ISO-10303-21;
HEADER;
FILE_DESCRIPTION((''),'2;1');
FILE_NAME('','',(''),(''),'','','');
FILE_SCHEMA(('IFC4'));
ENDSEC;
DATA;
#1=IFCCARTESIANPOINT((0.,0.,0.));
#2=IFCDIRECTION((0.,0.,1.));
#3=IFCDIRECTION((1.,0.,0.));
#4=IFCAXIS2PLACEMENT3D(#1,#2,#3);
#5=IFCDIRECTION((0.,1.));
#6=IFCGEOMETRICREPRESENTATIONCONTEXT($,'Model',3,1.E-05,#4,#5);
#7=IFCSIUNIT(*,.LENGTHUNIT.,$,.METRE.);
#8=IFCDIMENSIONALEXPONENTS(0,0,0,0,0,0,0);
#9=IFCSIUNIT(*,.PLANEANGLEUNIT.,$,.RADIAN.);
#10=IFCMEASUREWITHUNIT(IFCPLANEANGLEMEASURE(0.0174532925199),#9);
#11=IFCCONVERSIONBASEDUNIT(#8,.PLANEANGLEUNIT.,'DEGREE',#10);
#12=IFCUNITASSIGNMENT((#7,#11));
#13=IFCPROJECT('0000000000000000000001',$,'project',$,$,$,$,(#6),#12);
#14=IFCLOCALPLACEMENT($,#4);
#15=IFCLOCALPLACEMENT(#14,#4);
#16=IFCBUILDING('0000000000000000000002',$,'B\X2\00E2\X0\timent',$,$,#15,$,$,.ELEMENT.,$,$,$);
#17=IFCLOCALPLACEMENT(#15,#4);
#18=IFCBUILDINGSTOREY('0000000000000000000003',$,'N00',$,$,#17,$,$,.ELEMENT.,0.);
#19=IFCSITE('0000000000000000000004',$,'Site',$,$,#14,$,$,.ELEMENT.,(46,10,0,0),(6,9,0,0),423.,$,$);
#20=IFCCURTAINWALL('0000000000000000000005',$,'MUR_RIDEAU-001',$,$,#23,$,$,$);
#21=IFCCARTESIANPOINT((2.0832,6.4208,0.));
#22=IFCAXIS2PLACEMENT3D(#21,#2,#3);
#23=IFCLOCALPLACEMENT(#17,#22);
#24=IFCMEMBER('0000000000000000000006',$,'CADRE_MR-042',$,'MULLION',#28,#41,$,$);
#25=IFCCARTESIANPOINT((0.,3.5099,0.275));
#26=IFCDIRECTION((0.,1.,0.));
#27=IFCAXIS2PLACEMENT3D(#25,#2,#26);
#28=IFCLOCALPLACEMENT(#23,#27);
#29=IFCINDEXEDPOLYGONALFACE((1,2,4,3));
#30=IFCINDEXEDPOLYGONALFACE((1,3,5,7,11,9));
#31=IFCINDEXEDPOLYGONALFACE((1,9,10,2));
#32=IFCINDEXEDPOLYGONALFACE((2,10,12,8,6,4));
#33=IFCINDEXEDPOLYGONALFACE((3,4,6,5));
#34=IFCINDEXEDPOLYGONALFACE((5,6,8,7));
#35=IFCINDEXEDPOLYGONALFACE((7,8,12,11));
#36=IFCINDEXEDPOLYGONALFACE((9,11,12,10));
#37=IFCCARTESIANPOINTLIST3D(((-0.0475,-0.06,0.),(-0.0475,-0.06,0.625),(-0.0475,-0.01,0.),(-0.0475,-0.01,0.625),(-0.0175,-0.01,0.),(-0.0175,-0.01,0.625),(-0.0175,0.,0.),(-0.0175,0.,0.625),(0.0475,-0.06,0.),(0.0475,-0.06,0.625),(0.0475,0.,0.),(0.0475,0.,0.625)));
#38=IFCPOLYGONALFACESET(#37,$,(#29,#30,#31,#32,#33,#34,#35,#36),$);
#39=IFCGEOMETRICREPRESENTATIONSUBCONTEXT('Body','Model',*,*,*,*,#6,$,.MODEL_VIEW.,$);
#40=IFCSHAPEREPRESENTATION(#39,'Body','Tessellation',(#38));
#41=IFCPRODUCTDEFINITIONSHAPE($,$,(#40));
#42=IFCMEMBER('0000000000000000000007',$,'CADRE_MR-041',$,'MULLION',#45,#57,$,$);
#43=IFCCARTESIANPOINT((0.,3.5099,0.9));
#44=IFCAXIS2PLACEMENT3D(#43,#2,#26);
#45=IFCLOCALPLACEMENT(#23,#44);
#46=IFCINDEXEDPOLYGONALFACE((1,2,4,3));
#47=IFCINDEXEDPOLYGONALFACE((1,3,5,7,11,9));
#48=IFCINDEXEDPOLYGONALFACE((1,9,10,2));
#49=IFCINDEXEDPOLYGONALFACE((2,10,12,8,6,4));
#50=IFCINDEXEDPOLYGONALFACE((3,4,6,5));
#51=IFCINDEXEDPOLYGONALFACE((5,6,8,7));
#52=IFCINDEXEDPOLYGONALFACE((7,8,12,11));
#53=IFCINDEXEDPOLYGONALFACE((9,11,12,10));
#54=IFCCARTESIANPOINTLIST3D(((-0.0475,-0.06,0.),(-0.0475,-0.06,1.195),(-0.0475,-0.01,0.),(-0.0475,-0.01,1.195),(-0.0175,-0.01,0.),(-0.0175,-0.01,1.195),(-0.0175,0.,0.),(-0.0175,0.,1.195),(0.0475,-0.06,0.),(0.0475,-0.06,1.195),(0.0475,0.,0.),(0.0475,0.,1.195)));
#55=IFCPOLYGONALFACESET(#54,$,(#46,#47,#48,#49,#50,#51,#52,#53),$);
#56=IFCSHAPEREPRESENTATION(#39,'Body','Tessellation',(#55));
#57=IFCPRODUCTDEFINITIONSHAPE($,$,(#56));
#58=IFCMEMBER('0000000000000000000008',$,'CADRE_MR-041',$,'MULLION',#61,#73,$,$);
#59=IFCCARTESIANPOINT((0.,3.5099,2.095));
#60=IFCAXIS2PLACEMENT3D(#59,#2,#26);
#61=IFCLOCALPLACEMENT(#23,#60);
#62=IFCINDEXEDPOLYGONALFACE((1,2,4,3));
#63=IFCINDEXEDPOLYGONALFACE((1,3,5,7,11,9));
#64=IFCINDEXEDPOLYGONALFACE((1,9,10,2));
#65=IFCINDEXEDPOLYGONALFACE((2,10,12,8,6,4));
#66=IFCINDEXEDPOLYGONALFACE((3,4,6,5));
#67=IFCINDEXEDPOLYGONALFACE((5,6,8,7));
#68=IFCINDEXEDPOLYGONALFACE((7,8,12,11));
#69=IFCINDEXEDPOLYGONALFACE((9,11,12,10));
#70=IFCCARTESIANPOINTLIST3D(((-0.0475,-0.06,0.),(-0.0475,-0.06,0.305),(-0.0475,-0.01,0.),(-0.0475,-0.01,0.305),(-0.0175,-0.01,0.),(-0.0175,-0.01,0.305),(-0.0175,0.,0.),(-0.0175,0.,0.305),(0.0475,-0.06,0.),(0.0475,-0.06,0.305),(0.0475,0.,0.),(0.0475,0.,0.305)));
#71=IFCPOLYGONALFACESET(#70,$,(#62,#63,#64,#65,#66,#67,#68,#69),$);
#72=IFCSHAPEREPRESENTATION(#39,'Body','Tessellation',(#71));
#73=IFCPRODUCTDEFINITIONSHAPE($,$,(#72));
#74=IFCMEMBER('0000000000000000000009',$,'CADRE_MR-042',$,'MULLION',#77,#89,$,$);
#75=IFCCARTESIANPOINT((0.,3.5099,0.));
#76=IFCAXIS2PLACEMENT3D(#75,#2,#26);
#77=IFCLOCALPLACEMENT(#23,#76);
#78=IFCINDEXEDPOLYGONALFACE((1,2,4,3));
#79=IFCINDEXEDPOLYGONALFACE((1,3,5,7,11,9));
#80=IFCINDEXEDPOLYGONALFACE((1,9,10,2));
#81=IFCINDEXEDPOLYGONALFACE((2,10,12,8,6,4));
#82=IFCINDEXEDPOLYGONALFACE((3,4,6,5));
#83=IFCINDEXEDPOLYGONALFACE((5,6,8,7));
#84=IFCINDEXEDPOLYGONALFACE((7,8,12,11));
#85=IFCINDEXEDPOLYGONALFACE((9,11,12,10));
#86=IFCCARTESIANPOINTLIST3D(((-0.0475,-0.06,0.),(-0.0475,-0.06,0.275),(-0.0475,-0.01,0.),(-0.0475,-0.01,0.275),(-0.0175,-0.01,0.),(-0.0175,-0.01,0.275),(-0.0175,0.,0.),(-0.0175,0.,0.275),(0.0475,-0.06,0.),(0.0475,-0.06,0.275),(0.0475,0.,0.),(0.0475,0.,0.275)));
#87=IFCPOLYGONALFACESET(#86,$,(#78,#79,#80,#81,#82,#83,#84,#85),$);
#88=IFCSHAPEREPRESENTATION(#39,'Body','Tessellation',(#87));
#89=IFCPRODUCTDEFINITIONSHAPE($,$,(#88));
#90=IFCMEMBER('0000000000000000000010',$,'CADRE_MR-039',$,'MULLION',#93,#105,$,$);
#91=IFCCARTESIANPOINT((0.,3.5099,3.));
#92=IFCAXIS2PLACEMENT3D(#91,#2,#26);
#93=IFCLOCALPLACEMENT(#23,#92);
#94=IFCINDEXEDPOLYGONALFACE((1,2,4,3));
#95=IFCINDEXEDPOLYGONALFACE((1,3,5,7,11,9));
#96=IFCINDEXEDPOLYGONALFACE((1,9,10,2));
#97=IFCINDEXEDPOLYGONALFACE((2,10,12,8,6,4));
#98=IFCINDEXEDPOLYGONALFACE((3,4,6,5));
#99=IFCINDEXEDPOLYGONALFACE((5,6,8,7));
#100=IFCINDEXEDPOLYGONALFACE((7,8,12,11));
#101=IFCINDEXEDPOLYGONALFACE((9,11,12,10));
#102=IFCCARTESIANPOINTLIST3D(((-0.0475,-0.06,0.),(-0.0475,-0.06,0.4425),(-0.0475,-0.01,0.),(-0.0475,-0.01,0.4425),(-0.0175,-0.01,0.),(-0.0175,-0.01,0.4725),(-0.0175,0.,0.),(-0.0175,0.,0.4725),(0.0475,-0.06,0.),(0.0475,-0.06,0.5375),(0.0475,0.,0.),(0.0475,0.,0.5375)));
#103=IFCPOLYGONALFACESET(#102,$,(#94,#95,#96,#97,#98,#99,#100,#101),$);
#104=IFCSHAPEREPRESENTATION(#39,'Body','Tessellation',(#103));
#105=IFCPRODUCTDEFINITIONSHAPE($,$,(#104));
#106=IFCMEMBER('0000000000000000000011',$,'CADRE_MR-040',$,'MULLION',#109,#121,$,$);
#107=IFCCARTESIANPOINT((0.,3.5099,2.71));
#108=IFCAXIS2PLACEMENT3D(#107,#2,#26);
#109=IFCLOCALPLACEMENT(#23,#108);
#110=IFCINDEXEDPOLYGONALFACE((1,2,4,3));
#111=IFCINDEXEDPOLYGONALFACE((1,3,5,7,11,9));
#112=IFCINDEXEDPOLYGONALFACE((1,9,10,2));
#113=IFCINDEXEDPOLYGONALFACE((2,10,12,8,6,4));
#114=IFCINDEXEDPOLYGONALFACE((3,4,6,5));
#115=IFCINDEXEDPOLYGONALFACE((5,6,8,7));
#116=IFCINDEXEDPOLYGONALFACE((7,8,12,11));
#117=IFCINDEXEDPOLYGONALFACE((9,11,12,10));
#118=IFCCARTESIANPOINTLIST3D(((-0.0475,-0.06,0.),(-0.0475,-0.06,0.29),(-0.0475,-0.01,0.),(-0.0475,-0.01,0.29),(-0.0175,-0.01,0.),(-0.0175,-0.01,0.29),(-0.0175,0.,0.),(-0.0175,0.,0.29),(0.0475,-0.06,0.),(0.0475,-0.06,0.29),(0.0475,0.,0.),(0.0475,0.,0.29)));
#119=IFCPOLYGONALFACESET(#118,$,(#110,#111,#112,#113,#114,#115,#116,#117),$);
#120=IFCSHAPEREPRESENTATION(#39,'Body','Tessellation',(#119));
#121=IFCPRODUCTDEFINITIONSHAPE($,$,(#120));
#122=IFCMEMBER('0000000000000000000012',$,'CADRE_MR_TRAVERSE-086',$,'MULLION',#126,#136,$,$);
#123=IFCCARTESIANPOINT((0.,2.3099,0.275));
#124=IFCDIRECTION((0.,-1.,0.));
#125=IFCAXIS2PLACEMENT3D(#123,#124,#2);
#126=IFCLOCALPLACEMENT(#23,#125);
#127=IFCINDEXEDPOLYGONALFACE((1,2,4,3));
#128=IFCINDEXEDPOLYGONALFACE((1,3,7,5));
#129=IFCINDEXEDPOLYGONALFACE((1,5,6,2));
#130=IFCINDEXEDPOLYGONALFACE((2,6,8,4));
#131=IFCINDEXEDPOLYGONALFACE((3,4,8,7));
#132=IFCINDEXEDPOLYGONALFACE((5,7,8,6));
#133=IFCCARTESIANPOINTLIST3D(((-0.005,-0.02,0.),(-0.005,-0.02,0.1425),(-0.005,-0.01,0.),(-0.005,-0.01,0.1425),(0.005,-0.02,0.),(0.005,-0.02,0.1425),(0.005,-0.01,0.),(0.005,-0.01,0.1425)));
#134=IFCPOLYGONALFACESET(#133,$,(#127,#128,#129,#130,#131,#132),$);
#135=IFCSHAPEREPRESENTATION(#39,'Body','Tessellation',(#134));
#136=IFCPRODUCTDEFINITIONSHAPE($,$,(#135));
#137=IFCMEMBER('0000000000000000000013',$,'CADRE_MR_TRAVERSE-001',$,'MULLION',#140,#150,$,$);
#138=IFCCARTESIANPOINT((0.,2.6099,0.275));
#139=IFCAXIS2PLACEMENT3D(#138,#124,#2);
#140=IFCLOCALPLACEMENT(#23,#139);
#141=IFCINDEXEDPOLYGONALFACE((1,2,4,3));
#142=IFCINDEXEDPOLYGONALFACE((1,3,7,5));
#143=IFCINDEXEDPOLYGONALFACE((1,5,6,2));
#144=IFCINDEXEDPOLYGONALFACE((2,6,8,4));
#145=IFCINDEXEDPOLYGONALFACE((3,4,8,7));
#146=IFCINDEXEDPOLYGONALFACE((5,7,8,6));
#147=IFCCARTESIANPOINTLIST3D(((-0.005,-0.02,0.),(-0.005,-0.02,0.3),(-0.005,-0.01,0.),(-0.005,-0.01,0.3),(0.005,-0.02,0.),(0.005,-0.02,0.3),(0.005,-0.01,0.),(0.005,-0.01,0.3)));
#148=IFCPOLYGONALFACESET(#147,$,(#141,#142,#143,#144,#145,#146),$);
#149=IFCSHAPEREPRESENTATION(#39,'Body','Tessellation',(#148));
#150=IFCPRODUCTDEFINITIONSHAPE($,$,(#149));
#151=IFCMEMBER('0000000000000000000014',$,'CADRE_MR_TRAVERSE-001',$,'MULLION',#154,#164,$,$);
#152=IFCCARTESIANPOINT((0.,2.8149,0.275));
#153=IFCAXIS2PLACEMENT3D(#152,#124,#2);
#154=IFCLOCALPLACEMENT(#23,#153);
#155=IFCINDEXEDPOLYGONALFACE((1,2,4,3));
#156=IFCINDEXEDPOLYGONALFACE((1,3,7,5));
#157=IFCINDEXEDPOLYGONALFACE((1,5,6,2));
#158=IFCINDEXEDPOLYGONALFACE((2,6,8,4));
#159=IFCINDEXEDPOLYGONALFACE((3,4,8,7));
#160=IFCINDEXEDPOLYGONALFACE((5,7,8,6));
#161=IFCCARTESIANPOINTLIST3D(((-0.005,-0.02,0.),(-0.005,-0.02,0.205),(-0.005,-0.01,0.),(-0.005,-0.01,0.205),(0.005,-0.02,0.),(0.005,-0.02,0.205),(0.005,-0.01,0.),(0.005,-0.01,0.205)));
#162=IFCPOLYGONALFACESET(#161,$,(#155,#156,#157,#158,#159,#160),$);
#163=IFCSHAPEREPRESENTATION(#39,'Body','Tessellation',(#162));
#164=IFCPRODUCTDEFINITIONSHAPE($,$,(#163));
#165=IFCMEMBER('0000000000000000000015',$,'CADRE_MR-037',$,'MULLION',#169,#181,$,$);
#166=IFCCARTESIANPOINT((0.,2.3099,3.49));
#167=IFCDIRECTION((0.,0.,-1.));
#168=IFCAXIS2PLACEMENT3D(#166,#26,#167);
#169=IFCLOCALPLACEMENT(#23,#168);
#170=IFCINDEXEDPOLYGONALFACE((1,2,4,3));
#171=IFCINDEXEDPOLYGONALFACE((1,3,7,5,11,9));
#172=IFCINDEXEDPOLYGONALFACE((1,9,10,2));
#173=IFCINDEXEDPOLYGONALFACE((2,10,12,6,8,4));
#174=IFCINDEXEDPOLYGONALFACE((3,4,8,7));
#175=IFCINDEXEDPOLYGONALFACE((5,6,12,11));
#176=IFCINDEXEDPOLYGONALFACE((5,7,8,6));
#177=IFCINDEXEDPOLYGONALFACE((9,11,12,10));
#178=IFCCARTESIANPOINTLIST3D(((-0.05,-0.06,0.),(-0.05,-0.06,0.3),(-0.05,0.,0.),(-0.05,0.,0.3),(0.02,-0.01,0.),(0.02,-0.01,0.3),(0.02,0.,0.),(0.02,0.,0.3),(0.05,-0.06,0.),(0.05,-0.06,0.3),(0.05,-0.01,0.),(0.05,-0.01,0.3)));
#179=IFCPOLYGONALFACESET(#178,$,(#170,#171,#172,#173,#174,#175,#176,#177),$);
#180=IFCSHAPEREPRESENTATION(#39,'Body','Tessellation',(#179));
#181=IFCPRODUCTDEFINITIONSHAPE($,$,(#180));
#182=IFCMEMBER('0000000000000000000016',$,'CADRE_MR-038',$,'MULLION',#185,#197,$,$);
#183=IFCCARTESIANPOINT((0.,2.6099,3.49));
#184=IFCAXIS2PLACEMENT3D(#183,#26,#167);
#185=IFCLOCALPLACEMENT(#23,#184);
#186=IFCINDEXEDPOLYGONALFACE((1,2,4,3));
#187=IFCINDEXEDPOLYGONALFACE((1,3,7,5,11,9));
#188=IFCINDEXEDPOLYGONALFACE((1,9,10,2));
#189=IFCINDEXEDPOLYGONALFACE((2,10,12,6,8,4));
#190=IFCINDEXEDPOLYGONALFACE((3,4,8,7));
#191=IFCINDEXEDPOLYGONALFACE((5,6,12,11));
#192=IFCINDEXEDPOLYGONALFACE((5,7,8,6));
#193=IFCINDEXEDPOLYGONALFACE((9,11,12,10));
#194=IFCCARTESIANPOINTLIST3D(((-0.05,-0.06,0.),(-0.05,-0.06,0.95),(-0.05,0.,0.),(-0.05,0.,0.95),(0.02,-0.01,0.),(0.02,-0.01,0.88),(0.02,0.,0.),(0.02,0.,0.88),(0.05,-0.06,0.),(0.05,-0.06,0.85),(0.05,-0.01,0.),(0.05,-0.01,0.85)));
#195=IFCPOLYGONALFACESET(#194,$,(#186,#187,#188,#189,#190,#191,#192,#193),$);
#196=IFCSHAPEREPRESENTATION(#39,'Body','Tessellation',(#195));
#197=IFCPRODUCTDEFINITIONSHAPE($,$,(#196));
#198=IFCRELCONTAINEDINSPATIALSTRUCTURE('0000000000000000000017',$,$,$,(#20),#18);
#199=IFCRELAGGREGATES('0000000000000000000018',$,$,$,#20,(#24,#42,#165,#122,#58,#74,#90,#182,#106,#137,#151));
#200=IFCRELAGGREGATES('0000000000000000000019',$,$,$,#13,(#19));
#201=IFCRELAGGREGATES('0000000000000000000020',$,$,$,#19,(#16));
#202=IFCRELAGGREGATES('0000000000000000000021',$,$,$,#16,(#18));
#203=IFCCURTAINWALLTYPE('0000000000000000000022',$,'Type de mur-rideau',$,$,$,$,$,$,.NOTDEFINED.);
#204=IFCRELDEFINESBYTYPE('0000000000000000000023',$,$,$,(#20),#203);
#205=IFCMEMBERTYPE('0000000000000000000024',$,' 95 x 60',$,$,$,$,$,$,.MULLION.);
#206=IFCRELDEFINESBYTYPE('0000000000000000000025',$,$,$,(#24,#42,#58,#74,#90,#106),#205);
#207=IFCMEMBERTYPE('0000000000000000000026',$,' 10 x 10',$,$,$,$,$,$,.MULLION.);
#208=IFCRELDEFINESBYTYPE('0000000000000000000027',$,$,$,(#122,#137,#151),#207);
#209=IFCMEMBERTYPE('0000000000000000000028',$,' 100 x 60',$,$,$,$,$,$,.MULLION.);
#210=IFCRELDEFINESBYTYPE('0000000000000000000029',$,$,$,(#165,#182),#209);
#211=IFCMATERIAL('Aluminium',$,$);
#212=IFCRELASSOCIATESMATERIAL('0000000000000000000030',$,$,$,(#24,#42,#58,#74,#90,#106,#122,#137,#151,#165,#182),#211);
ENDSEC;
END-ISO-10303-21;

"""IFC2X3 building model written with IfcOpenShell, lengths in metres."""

from ifc_helpers import new_model, entity, si_unit, converted_unit, direction, frame, origin_with_axes, place, context, subcontext, project, spatial, polyline, outline, extrude, clip, halfspace, material, type_object, element, aggregate, save


model = new_model("IFC2X3")

# Units and contexts
model_context = context("Model", 3, precision=1e-05, world=origin_with_axes(), true_north=direction((0.0, 1.0)))
body_context = subcontext(model_context, "Body", "Model", "MODEL_VIEW")
ifc_project = project(units=[si_unit("LENGTHUNIT", "METRE"), converted_unit("PLANEANGLEUNIT", "DEGREE", entity("IfcPlaneAngleMeasure", 0.0174532925199), si_unit("PLANEANGLEUNIT", "RADIAN"), dimensions=[0, 0, 0, 0, 0, 0, 0])], contexts=[model_context])

# Site, building, storey
site_placement = place(None, origin_with_axes())
site = spatial("IfcSite", under=ifc_project, at=site_placement, Name="Site", CompositionType="ELEMENT", RefLatitude=(46, 10, 0, 0), RefLongitude=(6, 9, 0, 0), RefElevation=423.0)
building_placement = place(site_placement, origin_with_axes())
building = spatial("IfcBuilding", under=site, at=building_placement, Name="Bâtiment", CompositionType="ELEMENT")
storey_placement = place(building_placement, origin_with_axes())
storey = spatial("IfcBuildingStorey", under=building, at=storey_placement, Name="N00", CompositionType="ELEMENT", Elevation=0.0)

# Curtain wall, members
curtain_wall_type = type_object("IfcCurtainWallType", Name="Type de mur-rideau", PredefinedType="NOTDEFINED")
curtain_wall_placement = place(storey_placement, frame((2.0832, 6.4208, 0.0), z_axis=(0.0, 0.0, 1.0), x_axis=(1.0, 0.0, 0.0)))
curtain_wall = element("IfcCurtainWall", 1, at=curtain_wall_placement, inside=storey, type_object=curtain_wall_type, Name="MUR_RIDEAU-001")
ifc_material_1 = material(Name="Aluminium")
member_type_1 = type_object("IfcMemberType", Name=" 95 x 60", PredefinedType="MULLION")
member_1_placement = place(curtain_wall_placement, frame((0.0, 3.5099, 0.275), z_axis=(0.0, 0.0, 1.0), x_axis=(0.0, 1.0, 0.0)))
member_1 = element("IfcMember", 2, at=member_1_placement, type_object=member_type_1, material=ifc_material_1, Name="CADRE_MR-042", ObjectType="MULLION", context=body_context, shape_type="SweptSolid", body=[
    extrude(outline(polyline([(0.01, -0.0175), (0.01, -0.0475), (0.06, -0.0475), (0.06, 0.0475), (0.0, 0.0475), (0.0, -0.0175), (0.01, -0.0175)])), frame((0.0, 0.0, 0.0), z_axis=(0.0, 0.0, 1.0), x_axis=(0.0, -1.0, 0.0)), (0.0, 0.0, 1.0), 0.625),
])
member_2_placement = place(curtain_wall_placement, frame((0.0, 3.5099, 0.9), z_axis=(0.0, 0.0, 1.0), x_axis=(0.0, 1.0, 0.0)))
member_2 = element("IfcMember", 3, at=member_2_placement, type_object=member_type_1, material=ifc_material_1, Name="CADRE_MR-041", ObjectType="MULLION", context=body_context, shape_type="SweptSolid", body=[
    extrude(outline(polyline([(0.01, -0.0175), (0.01, -0.0475), (0.06, -0.0475), (0.06, 0.0475), (0.0, 0.0475), (0.0, -0.0175), (0.01, -0.0175)])), frame((0.0, 0.0, 0.0), z_axis=(0.0, 0.0, 1.0), x_axis=(0.0, -1.0, 0.0)), (0.0, 0.0, 1.0), 1.195),
])
member_3_placement = place(curtain_wall_placement, frame((0.0, 3.5099, 2.095), z_axis=(0.0, 0.0, 1.0), x_axis=(0.0, 1.0, 0.0)))
member_3 = element("IfcMember", 4, at=member_3_placement, type_object=member_type_1, material=ifc_material_1, Name="CADRE_MR-041", ObjectType="MULLION", context=body_context, shape_type="SweptSolid", body=[
    extrude(outline(polyline([(0.01, -0.0175), (0.01, -0.0475), (0.06, -0.0475), (0.06, 0.0475), (0.0, 0.0475), (0.0, -0.0175), (0.01, -0.0175)])), frame((0.0, 0.0, 0.0), z_axis=(0.0, 0.0, 1.0), x_axis=(0.0, -1.0, 0.0)), (0.0, 0.0, 1.0), 0.305),
])
member_4_placement = place(curtain_wall_placement, frame((0.0, 3.5099, 0.0), z_axis=(0.0, 0.0, 1.0), x_axis=(0.0, 1.0, 0.0)))
member_4 = element("IfcMember", 5, at=member_4_placement, type_object=member_type_1, material=ifc_material_1, Name="CADRE_MR-042", ObjectType="MULLION", context=body_context, shape_type="SweptSolid", body=[
    extrude(outline(polyline([(0.01, -0.0175), (0.01, -0.0475), (0.06, -0.0475), (0.06, 0.0475), (0.0, 0.0475), (0.0, -0.0175), (0.01, -0.0175)])), frame((0.0, 0.0, 0.0), z_axis=(0.0, 0.0, 1.0), x_axis=(0.0, -1.0, 0.0)), (0.0, 0.0, 1.0), 0.275),
])
member_5_placement = place(curtain_wall_placement, frame((0.0, 3.5099, 3.0), z_axis=(0.0, 0.0, 1.0), x_axis=(0.0, 1.0, 0.0)))
member_5 = element("IfcMember", 6, at=member_5_placement, type_object=member_type_1, material=ifc_material_1, Name="CADRE_MR-039", ObjectType="MULLION", context=body_context, shape_type="Clipping", body=[
    clip(extrude(outline(polyline([(0.01, -0.0175), (0.01, -0.0475), (0.06, -0.0475), (0.06, 0.0475), (0.0, 0.0475), (0.0, -0.0175), (0.01, -0.0175)])), frame((0.0, 0.0, 0.0), z_axis=(0.0, 0.0, 1.0), x_axis=(0.0, -1.0, 0.0)), (0.0, 0.0, 1.0), 0.5375), halfspace(frame((-0.245, 0.0, 0.245), z_axis=(0.707107, 0.0, -0.707107), x_axis=(0.0, 1.0, 0.0)), True)),
])
member_6_placement = place(curtain_wall_placement, frame((0.0, 3.5099, 2.71), z_axis=(0.0, 0.0, 1.0), x_axis=(0.0, 1.0, 0.0)))
member_6 = element("IfcMember", 7, at=member_6_placement, type_object=member_type_1, material=ifc_material_1, Name="CADRE_MR-040", ObjectType="MULLION", context=body_context, shape_type="SweptSolid", body=[
    extrude(outline(polyline([(0.01, -0.0175), (0.01, -0.0475), (0.06, -0.0475), (0.06, 0.0475), (0.0, 0.0475), (0.0, -0.0175), (0.01, -0.0175)])), frame((0.0, 0.0, 0.0), z_axis=(0.0, 0.0, 1.0), x_axis=(0.0, -1.0, 0.0)), (0.0, 0.0, 1.0), 0.29),
])
member_type_2 = type_object("IfcMemberType", Name=" 10 x 10", PredefinedType="MULLION")
member_7_placement = place(curtain_wall_placement, frame((0.0, 2.3099, 0.275), z_axis=(0.0, -1.0, 0.0), x_axis=(0.0, 0.0, 1.0)))
member_7 = element("IfcMember", 8, at=member_7_placement, type_object=member_type_2, material=ifc_material_1, Name="CADRE_MR_TRAVERSE-086", ObjectType="MULLION", context=body_context, shape_type="SweptSolid", body=[
    extrude(outline(polyline([(-0.02, -0.005), (-0.01, -0.005), (-0.01, 0.005), (-0.02, 0.005), (-0.02, -0.005)])), frame((0.0, 0.0, 0.0), z_axis=(0.0, 0.0, 1.0), x_axis=(0.0, 1.0, 0.0)), (0.0, 0.0, 1.0), 0.1425),
])
member_8_placement = place(curtain_wall_placement, frame((0.0, 2.6099, 0.275), z_axis=(0.0, -1.0, 0.0), x_axis=(0.0, 0.0, 1.0)))
member_8 = element("IfcMember", 9, at=member_8_placement, type_object=member_type_2, material=ifc_material_1, Name="CADRE_MR_TRAVERSE-001", ObjectType="MULLION", context=body_context, shape_type="SweptSolid", body=[
    extrude(outline(polyline([(-0.02, -0.005), (-0.01, -0.005), (-0.01, 0.005), (-0.02, 0.005), (-0.02, -0.005)])), frame((0.0, 0.0, 0.0), z_axis=(0.0, 0.0, 1.0), x_axis=(0.0, 1.0, 0.0)), (0.0, 0.0, 1.0), 0.3),
])
member_9_placement = place(curtain_wall_placement, frame((0.0, 2.8149, 0.275), z_axis=(0.0, -1.0, 0.0), x_axis=(0.0, 0.0, 1.0)))
member_9 = element("IfcMember", 10, at=member_9_placement, type_object=member_type_2, material=ifc_material_1, Name="CADRE_MR_TRAVERSE-001", ObjectType="MULLION", context=body_context, shape_type="SweptSolid", body=[
    extrude(outline(polyline([(-0.02, -0.005), (-0.01, -0.005), (-0.01, 0.005), (-0.02, 0.005), (-0.02, -0.005)])), frame((0.0, 0.0, 0.0), z_axis=(0.0, 0.0, 1.0), x_axis=(0.0, 1.0, 0.0)), (0.0, 0.0, 1.0), 0.205),
])
member_type_3 = type_object("IfcMemberType", Name=" 100 x 60", PredefinedType="MULLION")
member_10_placement = place(curtain_wall_placement, frame((0.0, 2.3099, 3.49), z_axis=(0.0, 1.0, 0.0), x_axis=(0.0, 0.0, -1.0)))
member_10 = element("IfcMember", 11, at=member_10_placement, type_object=member_type_3, material=ifc_material_1, Name="CADRE_MR-037", ObjectType="MULLION", context=body_context, shape_type="SweptSolid", body=[
    extrude(outline(polyline([(0.01, 0.02), (0.0, 0.02), (0.0, -0.05), (0.06, -0.05), (0.06, 0.05), (0.01, 0.05), (0.01, 0.02)])), frame((0.0, 0.0, 0.0), z_axis=(0.0, 0.0, 1.0), x_axis=(0.0, -1.0, 0.0)), (0.0, 0.0, 1.0), 0.3),
])
member_11_placement = place(curtain_wall_placement, frame((0.0, 2.6099, 3.49), z_axis=(0.0, 1.0, 0.0), x_axis=(0.0, 0.0, -1.0)))
member_11 = element("IfcMember", 12, at=member_11_placement, type_object=member_type_3, material=ifc_material_1, Name="CADRE_MR-038", ObjectType="MULLION", context=body_context, shape_type="Clipping", body=[
    clip(extrude(outline(polyline([(0.01, 0.02), (0.0, 0.02), (0.0, -0.05), (0.06, -0.05), (0.06, 0.05), (0.01, 0.05), (0.01, 0.02)])), frame((0.0, 0.0, 0.0), z_axis=(0.0, 0.0, 1.0), x_axis=(0.0, -1.0, 0.0)), (0.0, 0.0, 1.0), 0.95), halfspace(frame((0.45, 0.0, 0.45), z_axis=(-0.707107, 0.0, -0.707107), x_axis=(0.0, 1.0, 0.0)), True)),
])
aggregate(curtain_wall, [member_1, member_2, member_10, member_7, member_3, member_4, member_5, member_11, member_6, member_8, member_9])

save(model, "model.ifc")
